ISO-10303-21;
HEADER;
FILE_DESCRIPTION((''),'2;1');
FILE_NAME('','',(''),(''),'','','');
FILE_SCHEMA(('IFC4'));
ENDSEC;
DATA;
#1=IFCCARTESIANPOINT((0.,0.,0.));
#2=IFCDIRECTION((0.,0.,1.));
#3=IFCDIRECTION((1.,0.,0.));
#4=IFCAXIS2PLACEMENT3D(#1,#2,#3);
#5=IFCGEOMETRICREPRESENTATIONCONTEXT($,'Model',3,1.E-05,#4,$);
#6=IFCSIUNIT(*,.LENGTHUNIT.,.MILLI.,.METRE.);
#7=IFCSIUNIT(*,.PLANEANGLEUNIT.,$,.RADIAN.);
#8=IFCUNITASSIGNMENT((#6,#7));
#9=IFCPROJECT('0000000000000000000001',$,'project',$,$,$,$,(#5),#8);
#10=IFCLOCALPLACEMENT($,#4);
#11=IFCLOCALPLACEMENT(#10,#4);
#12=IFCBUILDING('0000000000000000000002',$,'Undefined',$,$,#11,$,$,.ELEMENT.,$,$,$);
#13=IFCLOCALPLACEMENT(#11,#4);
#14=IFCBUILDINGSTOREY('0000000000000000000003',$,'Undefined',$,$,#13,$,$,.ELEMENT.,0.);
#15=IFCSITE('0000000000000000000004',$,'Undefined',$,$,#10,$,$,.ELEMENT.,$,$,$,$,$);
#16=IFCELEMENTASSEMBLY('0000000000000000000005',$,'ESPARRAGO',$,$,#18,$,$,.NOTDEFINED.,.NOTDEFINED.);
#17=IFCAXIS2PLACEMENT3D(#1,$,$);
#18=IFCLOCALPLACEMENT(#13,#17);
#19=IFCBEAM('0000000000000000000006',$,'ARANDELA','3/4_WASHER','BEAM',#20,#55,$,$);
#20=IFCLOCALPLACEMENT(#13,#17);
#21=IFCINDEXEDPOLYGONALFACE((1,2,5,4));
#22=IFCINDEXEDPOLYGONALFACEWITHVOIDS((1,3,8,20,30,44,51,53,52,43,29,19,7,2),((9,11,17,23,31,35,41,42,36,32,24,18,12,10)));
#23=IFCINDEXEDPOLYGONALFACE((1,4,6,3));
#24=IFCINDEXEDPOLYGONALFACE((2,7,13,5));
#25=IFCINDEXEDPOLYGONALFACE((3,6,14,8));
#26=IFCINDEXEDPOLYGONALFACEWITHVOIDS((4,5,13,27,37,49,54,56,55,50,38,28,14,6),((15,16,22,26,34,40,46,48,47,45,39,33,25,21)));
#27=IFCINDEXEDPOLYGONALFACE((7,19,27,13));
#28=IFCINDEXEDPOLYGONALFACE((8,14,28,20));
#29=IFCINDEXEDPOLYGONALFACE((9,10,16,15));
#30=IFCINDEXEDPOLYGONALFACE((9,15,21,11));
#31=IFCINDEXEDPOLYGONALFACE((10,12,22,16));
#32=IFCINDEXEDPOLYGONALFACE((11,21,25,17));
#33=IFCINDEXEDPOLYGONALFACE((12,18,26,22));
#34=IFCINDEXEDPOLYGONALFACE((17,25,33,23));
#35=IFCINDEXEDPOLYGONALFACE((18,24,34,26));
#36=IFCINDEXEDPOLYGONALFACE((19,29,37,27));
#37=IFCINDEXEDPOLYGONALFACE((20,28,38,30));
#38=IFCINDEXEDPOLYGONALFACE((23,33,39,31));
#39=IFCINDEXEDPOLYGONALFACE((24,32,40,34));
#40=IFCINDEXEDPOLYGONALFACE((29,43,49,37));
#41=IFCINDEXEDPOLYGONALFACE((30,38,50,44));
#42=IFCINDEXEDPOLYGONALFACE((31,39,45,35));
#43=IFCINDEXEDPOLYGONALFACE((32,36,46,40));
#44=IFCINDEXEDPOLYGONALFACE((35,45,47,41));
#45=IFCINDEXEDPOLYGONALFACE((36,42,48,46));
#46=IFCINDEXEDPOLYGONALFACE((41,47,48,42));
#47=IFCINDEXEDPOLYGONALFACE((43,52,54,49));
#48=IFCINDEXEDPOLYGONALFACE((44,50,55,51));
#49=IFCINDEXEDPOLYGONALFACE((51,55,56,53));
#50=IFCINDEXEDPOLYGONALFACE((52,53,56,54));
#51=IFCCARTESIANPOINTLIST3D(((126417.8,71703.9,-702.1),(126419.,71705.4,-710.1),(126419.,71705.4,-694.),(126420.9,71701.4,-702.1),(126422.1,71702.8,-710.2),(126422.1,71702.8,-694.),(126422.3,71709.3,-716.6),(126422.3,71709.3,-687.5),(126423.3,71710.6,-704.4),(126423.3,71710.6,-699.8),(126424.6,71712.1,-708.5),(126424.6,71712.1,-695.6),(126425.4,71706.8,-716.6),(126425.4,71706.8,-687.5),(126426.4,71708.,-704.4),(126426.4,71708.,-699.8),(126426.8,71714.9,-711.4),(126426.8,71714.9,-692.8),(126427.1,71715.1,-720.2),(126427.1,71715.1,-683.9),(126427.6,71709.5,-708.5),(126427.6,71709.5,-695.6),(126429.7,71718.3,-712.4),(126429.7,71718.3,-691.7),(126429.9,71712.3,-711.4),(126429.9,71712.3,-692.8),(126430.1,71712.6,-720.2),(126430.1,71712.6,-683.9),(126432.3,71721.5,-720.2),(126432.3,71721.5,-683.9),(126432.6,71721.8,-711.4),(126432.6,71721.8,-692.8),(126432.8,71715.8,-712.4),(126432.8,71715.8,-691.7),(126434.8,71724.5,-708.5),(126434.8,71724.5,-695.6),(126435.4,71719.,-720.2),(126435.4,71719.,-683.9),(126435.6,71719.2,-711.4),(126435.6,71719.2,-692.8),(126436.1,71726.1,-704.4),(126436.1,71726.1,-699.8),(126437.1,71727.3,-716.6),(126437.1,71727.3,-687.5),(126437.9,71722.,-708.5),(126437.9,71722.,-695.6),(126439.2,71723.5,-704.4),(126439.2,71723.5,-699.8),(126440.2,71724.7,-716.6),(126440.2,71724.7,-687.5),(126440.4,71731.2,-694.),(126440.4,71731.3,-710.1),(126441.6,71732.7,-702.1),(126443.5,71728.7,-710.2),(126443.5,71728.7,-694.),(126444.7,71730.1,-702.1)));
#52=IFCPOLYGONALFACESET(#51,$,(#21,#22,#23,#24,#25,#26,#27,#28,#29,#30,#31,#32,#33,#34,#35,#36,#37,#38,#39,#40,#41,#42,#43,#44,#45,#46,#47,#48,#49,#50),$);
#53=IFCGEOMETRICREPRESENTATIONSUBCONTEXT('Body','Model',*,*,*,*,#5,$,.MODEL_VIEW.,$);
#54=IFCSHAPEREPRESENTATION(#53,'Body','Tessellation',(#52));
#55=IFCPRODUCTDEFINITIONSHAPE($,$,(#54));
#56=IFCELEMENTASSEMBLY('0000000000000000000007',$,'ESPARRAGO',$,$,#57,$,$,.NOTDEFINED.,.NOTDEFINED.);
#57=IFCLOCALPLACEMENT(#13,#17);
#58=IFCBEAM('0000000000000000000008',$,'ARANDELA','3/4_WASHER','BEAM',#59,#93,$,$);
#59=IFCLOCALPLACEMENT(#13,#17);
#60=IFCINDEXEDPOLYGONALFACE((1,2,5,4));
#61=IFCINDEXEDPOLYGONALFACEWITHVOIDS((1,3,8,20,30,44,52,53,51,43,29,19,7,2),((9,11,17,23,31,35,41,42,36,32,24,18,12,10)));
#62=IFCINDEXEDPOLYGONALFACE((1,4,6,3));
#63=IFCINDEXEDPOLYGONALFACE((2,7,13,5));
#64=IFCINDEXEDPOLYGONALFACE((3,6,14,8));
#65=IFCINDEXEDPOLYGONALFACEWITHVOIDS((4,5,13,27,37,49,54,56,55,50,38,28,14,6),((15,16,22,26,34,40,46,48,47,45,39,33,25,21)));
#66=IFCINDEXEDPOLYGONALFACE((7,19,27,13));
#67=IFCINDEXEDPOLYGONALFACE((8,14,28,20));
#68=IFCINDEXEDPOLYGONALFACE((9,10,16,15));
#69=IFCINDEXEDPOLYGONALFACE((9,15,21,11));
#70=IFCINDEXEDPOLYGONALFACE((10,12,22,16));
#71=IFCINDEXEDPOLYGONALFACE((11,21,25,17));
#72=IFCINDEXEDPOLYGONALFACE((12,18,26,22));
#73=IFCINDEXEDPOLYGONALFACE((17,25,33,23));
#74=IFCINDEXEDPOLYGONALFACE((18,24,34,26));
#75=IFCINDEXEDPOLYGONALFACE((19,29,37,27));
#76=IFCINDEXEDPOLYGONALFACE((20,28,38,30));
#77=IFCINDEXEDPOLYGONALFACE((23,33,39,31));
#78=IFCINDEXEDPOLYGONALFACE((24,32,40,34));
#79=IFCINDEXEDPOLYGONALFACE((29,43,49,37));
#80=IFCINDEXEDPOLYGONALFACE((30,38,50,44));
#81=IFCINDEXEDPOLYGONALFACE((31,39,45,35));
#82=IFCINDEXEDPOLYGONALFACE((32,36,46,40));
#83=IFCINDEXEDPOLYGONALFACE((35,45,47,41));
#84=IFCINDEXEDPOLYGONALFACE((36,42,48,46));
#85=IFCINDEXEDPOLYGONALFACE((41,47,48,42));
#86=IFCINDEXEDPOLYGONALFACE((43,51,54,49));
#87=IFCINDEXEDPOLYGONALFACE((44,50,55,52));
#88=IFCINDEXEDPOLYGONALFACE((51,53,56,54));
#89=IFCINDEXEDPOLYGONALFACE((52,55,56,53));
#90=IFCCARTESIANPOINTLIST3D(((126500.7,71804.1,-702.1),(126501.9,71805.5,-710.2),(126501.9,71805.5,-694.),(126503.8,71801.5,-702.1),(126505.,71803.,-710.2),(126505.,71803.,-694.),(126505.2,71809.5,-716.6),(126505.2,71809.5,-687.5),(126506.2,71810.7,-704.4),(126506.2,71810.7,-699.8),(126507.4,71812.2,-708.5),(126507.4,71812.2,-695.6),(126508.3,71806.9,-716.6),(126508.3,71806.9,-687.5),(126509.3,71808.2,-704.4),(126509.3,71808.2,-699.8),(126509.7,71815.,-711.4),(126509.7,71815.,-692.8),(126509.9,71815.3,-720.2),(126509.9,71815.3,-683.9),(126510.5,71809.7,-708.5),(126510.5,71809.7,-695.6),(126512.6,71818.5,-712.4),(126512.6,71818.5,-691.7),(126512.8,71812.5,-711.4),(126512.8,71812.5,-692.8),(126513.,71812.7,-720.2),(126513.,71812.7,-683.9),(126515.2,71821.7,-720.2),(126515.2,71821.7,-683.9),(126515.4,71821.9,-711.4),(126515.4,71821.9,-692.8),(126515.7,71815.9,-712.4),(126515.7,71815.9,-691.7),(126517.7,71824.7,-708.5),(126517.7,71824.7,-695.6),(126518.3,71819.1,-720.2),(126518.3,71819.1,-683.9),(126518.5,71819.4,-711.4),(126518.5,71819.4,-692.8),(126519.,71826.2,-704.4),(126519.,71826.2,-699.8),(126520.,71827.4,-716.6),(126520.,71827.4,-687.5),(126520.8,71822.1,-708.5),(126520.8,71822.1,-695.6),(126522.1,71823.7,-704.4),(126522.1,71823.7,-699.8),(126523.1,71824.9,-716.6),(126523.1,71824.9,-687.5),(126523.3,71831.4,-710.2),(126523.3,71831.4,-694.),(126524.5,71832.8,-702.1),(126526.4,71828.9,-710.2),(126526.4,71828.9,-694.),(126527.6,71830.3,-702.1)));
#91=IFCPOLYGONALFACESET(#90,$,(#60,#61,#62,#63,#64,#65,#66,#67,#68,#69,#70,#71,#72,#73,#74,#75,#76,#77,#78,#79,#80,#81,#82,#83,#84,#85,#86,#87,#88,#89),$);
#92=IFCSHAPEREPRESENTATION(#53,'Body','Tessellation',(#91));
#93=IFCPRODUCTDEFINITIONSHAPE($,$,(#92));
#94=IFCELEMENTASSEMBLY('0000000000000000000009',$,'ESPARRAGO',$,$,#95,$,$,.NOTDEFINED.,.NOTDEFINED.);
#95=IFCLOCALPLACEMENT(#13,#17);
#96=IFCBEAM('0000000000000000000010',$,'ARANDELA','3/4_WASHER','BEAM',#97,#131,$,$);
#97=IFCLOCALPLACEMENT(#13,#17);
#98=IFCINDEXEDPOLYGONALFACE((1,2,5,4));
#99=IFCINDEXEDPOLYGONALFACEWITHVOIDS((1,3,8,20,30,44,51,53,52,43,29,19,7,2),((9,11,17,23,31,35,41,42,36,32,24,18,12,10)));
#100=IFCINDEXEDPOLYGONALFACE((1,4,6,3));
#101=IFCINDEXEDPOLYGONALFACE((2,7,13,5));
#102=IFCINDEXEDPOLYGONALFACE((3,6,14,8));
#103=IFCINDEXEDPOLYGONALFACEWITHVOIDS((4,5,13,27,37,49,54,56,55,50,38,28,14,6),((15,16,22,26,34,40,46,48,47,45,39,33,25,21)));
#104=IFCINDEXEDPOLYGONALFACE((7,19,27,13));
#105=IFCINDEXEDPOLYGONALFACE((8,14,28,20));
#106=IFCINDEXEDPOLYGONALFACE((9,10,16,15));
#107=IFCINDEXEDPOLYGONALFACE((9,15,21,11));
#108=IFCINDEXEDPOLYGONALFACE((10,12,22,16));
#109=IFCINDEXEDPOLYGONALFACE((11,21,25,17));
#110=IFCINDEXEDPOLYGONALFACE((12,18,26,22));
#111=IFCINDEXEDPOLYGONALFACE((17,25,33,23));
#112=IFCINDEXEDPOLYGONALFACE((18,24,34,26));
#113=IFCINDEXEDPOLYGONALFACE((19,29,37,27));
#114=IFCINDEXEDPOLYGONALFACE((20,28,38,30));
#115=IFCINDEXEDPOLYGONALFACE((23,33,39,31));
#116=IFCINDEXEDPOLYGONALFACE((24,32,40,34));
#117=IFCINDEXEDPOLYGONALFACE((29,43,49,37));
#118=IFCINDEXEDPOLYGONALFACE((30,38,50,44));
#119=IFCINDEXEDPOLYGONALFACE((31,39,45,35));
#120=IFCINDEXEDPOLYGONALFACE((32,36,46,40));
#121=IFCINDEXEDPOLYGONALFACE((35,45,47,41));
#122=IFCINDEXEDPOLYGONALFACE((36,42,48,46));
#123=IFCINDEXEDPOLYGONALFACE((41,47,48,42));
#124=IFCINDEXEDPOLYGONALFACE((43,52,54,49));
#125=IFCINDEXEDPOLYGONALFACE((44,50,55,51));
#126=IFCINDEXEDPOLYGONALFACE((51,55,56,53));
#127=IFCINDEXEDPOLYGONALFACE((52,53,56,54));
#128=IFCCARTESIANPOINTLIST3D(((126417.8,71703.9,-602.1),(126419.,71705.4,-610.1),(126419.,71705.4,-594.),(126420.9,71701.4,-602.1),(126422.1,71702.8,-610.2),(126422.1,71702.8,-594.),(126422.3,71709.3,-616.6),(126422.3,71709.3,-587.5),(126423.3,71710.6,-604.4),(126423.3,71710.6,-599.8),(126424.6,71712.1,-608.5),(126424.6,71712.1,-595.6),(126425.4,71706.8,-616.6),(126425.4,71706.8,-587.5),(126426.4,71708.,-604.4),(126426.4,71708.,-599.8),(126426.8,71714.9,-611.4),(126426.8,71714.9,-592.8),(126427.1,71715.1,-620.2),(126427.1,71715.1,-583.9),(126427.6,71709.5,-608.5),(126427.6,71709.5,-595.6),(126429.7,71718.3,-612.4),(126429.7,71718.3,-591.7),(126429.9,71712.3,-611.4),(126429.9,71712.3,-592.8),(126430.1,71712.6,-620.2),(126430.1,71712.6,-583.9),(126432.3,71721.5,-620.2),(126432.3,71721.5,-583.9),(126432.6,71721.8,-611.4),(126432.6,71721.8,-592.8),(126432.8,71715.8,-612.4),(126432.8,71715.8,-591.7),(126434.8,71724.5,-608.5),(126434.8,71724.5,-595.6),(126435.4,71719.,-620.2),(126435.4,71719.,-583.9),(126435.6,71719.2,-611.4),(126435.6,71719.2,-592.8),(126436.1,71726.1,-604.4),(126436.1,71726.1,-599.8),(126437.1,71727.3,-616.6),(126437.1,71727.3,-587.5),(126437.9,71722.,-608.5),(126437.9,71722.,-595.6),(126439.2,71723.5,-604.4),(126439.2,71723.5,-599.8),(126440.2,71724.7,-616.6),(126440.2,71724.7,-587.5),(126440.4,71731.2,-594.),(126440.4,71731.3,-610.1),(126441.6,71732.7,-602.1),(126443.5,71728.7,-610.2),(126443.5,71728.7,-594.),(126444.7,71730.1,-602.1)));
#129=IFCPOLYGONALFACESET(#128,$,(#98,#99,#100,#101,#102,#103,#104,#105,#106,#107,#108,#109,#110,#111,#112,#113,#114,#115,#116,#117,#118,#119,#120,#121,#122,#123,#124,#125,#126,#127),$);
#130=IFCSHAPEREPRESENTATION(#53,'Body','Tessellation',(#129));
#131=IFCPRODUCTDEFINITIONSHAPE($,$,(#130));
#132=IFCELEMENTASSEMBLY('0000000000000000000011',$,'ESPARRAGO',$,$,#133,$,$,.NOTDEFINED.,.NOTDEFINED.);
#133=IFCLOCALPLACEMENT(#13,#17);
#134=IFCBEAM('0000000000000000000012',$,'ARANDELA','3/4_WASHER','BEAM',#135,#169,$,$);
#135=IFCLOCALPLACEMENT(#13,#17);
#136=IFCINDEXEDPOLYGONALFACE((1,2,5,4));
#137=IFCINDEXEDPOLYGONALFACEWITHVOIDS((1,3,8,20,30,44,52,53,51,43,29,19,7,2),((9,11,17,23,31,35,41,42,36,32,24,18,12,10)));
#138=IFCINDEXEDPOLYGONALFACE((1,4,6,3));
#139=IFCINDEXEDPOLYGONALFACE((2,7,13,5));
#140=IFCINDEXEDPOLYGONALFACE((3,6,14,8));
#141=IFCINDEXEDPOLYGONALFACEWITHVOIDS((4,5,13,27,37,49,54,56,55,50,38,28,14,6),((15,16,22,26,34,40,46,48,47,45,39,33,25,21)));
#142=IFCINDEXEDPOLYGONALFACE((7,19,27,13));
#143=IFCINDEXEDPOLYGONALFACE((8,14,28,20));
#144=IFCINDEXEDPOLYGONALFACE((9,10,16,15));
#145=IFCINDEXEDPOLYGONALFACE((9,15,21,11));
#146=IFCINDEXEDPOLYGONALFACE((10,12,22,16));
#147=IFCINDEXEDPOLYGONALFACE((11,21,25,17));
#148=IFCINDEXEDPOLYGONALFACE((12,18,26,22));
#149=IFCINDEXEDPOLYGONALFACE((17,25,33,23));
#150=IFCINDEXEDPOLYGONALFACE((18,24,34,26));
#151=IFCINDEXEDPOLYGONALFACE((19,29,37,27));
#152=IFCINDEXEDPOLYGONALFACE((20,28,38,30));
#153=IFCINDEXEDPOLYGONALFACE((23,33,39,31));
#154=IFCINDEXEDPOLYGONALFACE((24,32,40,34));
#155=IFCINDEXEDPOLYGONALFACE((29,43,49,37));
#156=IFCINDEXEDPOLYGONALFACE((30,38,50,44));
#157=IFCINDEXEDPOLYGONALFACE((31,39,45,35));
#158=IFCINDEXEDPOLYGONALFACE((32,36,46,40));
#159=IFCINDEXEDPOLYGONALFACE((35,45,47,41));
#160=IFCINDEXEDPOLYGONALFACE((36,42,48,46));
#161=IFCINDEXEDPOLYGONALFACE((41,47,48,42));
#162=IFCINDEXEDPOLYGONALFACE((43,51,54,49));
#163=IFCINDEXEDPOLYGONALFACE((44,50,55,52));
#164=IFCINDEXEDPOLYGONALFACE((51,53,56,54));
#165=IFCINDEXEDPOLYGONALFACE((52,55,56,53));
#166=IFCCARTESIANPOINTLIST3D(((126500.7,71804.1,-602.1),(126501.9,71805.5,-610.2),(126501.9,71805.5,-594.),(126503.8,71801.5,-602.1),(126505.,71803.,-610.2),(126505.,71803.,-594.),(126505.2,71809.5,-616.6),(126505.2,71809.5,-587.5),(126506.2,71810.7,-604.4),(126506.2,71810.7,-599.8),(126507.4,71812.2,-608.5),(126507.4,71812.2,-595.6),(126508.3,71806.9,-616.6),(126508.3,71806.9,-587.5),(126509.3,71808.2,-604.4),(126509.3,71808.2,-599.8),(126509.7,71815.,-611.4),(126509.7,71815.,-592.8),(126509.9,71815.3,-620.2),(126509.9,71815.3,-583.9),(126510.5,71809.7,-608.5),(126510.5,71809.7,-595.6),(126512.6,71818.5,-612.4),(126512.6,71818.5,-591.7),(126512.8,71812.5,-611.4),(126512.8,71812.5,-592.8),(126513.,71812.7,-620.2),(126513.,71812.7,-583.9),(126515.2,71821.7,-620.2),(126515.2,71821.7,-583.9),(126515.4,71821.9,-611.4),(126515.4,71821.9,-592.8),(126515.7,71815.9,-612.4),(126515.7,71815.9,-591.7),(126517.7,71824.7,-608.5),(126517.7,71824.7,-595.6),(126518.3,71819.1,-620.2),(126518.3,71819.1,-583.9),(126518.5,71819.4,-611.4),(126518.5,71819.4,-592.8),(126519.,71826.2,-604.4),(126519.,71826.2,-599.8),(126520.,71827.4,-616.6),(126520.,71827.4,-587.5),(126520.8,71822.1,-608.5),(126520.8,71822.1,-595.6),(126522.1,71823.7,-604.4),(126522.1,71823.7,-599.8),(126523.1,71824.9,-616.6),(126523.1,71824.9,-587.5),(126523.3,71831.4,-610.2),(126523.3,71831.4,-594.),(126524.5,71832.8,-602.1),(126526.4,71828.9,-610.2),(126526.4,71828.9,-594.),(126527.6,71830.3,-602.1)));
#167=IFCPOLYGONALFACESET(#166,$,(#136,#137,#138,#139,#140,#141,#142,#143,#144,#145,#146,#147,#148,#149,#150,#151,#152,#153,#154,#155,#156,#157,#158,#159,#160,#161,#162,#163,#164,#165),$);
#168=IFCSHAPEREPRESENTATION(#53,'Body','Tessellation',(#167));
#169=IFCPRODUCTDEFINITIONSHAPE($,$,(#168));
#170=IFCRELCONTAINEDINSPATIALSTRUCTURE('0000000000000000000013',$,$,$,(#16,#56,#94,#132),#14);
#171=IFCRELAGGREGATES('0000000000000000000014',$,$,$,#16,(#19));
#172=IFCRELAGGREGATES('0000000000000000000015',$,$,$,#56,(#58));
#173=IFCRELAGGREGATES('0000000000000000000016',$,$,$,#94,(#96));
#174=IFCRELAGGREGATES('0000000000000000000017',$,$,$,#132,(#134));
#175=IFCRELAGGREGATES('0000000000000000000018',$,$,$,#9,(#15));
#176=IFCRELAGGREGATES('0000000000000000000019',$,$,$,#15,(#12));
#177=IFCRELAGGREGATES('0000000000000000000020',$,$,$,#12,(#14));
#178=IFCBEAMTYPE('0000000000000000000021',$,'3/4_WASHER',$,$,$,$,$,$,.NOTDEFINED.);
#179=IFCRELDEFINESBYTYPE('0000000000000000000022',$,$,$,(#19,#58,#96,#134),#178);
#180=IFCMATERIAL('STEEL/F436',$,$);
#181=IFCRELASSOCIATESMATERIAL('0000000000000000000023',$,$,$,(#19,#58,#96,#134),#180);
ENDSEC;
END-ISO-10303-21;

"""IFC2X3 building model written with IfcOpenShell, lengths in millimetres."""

from ifc_helpers import new_model, si_unit, frame, origin_with_axes, place, context, subcontext, project, spatial, polyline, outline, extrude, material, type_object, element, aggregate, save


model = new_model("IFC2X3")

# Units and contexts
model_context = context("Model", 3, precision=1e-05, world=origin_with_axes())
body_context = subcontext(model_context, "Body", "Model", "MODEL_VIEW")
ifc_project = project(units=[si_unit("LENGTHUNIT", "METRE", prefix="MILLI"), si_unit("PLANEANGLEUNIT", "RADIAN")], contexts=[model_context])

# Site, building, storey
site_placement = place(None, origin_with_axes())
site = spatial("IfcSite", under=ifc_project, at=site_placement, Name="Undefined", CompositionType="ELEMENT")
building_placement = place(site_placement, origin_with_axes())
building = spatial("IfcBuilding", under=site, at=building_placement, Name="Undefined", CompositionType="ELEMENT")
storey_placement = place(building_placement, origin_with_axes())
storey = spatial("IfcBuildingStorey", under=building, at=storey_placement, Name="Undefined", CompositionType="ELEMENT", Elevation=0.0)

# Element assemblies, beams
assembly_1_placement = place(storey_placement, origin_with_axes())
assembly_1 = element("IfcElementAssembly", 1, at=assembly_1_placement, inside=storey, Name="ESPARRAGO", AssemblyPlace="NOTDEFINED", PredefinedType="NOTDEFINED")
ifc_material_1 = material(Name="STEEL/F436")
beam_type_1 = type_object("IfcBeamType", Name="3/4_WASHER", PredefinedType="NOTDEFINED")
beam_1_placement = place(assembly_1_placement, frame((126429.7, 71718.3, -702.1), z_axis=(0.000066, -0.000055, 1.0), x_axis=(0.7704, -0.637561, -0.000086)))
beam_1 = element("IfcBeam", 2, at=beam_1_placement, type_object=beam_type_1, material=ifc_material_1, Name="ARANDELA", Description="3/4_WASHER", ObjectType="BEAM", context=body_context, shape_type="SweptSolid", body=[
    extrude(outline(polyline([(-11.6, -14.6), (-16.8, -8.1), (-18.6, 0.0), (-16.8, 8.1), (-11.6, 14.6), (-4.2, 18.2), (4.2, 18.2), (11.6, 14.6), (16.8, 8.1), (18.6, 0.0), (16.8, -8.1), (11.6, -14.6), (4.2, -18.2), (-4.2, -18.2), (-11.6, -14.6)]), holes=[polyline([(-4.5, 9.3), (-8.1, 6.4), (-10.1, 2.3), (-10.1, -2.3), (-8.1, -6.4), (-4.5, -9.3), (0.0, -10.3), (4.5, -9.3), (8.1, -6.4), (10.1, -2.3), (10.1, 2.3), (8.1, 6.4), (4.5, 9.3), (0.0, 10.3), (-4.5, 9.3)])]), frame((4.0, 0.0, 0.0), z_axis=(-1.0, 0.0, 0.0), x_axis=(0.0, -1.0, 0.0)), (0.0, 0.0, 1.0), 4.0),
])
assembly_2_placement = place(storey_placement, origin_with_axes())
assembly_2 = element("IfcElementAssembly", 3, at=assembly_2_placement, inside=storey, Name="ESPARRAGO", AssemblyPlace="NOTDEFINED", PredefinedType="NOTDEFINED")
beam_2_placement = place(assembly_2_placement, frame((126512.6, 71818.5, -702.1), z_axis=(0.000066, -0.000055, 1.0), x_axis=(0.7704, -0.637561, -0.000086)))
beam_2 = element("IfcBeam", 4, at=beam_2_placement, type_object=beam_type_1, material=ifc_material_1, Name="ARANDELA", Description="3/4_WASHER", ObjectType="BEAM", context=body_context, shape_type="SweptSolid", body=[
    extrude(outline(polyline([(-11.6, -14.6), (-16.8, -8.1), (-18.6, 0.0), (-16.8, 8.1), (-11.6, 14.6), (-4.2, 18.2), (4.2, 18.2), (11.6, 14.6), (16.8, 8.1), (18.6, 0.0), (16.8, -8.1), (11.6, -14.6), (4.2, -18.2), (-4.2, -18.2), (-11.6, -14.6)]), holes=[polyline([(-4.5, 9.3), (-8.1, 6.4), (-10.1, 2.3), (-10.1, -2.3), (-8.1, -6.4), (-4.5, -9.3), (0.0, -10.3), (4.5, -9.3), (8.1, -6.4), (10.1, -2.3), (10.1, 2.3), (8.1, 6.4), (4.5, 9.3), (0.0, 10.3), (-4.5, 9.3)])]), frame((4.0, 0.0, 0.0), z_axis=(-1.0, 0.0, 0.0), x_axis=(0.0, -1.0, 0.0)), (0.0, 0.0, 1.0), 4.0),
])
assembly_3_placement = place(storey_placement, origin_with_axes())
assembly_3 = element("IfcElementAssembly", 5, at=assembly_3_placement, inside=storey, Name="ESPARRAGO", AssemblyPlace="NOTDEFINED", PredefinedType="NOTDEFINED")
beam_3_placement = place(assembly_3_placement, frame((126429.7, 71718.3, -602.1), z_axis=(0.000066, -0.000055, 1.0), x_axis=(0.7704, -0.637561, -0.000086)))
beam_3 = element("IfcBeam", 6, at=beam_3_placement, type_object=beam_type_1, material=ifc_material_1, Name="ARANDELA", Description="3/4_WASHER", ObjectType="BEAM", context=body_context, shape_type="SweptSolid", body=[
    extrude(outline(polyline([(-11.6, -14.6), (-16.8, -8.1), (-18.6, 0.0), (-16.8, 8.1), (-11.6, 14.6), (-4.2, 18.2), (4.2, 18.2), (11.6, 14.6), (16.8, 8.1), (18.6, 0.0), (16.8, -8.1), (11.6, -14.6), (4.2, -18.2), (-4.2, -18.2), (-11.6, -14.6)]), holes=[polyline([(-4.5, 9.3), (-8.1, 6.4), (-10.1, 2.3), (-10.1, -2.3), (-8.1, -6.4), (-4.5, -9.3), (0.0, -10.3), (4.5, -9.3), (8.1, -6.4), (10.1, -2.3), (10.1, 2.3), (8.1, 6.4), (4.5, 9.3), (0.0, 10.3), (-4.5, 9.3)])]), frame((4.0, 0.0, 0.0), z_axis=(-1.0, 0.0, 0.0), x_axis=(0.0, -1.0, 0.0)), (0.0, 0.0, 1.0), 4.0),
])
assembly_4_placement = place(storey_placement, origin_with_axes())
assembly_4 = element("IfcElementAssembly", 7, at=assembly_4_placement, inside=storey, Name="ESPARRAGO", AssemblyPlace="NOTDEFINED", PredefinedType="NOTDEFINED")
beam_4_placement = place(assembly_4_placement, frame((126512.6, 71818.5, -602.1), z_axis=(0.000066, -0.000055, 1.0), x_axis=(0.7704, -0.637561, -0.000086)))
beam_4 = element("IfcBeam", 8, at=beam_4_placement, type_object=beam_type_1, material=ifc_material_1, Name="ARANDELA", Description="3/4_WASHER", ObjectType="BEAM", context=body_context, shape_type="SweptSolid", body=[
    extrude(outline(polyline([(-11.6, -14.6), (-16.8, -8.1), (-18.6, 0.0), (-16.8, 8.1), (-11.6, 14.6), (-4.2, 18.2), (4.2, 18.2), (11.6, 14.6), (16.8, 8.1), (18.6, 0.0), (16.8, -8.1), (11.6, -14.6), (4.2, -18.2), (-4.2, -18.2), (-11.6, -14.6)]), holes=[polyline([(-4.5, 9.3), (-8.1, 6.4), (-10.1, 2.3), (-10.1, -2.3), (-8.1, -6.4), (-4.5, -9.3), (0.0, -10.3), (4.5, -9.3), (8.1, -6.4), (10.1, -2.3), (10.1, 2.3), (8.1, 6.4), (4.5, 9.3), (0.0, 10.3), (-4.5, 9.3)])]), frame((4.0, 0.0, 0.0), z_axis=(-1.0, 0.0, 0.0), x_axis=(0.0, -1.0, 0.0)), (0.0, 0.0, 1.0), 4.0),
])

aggregate(assembly_1, [beam_1])
aggregate(assembly_2, [beam_2])
aggregate(assembly_3, [beam_3])
aggregate(assembly_4, [beam_4])

save(model, "model.ifc")
